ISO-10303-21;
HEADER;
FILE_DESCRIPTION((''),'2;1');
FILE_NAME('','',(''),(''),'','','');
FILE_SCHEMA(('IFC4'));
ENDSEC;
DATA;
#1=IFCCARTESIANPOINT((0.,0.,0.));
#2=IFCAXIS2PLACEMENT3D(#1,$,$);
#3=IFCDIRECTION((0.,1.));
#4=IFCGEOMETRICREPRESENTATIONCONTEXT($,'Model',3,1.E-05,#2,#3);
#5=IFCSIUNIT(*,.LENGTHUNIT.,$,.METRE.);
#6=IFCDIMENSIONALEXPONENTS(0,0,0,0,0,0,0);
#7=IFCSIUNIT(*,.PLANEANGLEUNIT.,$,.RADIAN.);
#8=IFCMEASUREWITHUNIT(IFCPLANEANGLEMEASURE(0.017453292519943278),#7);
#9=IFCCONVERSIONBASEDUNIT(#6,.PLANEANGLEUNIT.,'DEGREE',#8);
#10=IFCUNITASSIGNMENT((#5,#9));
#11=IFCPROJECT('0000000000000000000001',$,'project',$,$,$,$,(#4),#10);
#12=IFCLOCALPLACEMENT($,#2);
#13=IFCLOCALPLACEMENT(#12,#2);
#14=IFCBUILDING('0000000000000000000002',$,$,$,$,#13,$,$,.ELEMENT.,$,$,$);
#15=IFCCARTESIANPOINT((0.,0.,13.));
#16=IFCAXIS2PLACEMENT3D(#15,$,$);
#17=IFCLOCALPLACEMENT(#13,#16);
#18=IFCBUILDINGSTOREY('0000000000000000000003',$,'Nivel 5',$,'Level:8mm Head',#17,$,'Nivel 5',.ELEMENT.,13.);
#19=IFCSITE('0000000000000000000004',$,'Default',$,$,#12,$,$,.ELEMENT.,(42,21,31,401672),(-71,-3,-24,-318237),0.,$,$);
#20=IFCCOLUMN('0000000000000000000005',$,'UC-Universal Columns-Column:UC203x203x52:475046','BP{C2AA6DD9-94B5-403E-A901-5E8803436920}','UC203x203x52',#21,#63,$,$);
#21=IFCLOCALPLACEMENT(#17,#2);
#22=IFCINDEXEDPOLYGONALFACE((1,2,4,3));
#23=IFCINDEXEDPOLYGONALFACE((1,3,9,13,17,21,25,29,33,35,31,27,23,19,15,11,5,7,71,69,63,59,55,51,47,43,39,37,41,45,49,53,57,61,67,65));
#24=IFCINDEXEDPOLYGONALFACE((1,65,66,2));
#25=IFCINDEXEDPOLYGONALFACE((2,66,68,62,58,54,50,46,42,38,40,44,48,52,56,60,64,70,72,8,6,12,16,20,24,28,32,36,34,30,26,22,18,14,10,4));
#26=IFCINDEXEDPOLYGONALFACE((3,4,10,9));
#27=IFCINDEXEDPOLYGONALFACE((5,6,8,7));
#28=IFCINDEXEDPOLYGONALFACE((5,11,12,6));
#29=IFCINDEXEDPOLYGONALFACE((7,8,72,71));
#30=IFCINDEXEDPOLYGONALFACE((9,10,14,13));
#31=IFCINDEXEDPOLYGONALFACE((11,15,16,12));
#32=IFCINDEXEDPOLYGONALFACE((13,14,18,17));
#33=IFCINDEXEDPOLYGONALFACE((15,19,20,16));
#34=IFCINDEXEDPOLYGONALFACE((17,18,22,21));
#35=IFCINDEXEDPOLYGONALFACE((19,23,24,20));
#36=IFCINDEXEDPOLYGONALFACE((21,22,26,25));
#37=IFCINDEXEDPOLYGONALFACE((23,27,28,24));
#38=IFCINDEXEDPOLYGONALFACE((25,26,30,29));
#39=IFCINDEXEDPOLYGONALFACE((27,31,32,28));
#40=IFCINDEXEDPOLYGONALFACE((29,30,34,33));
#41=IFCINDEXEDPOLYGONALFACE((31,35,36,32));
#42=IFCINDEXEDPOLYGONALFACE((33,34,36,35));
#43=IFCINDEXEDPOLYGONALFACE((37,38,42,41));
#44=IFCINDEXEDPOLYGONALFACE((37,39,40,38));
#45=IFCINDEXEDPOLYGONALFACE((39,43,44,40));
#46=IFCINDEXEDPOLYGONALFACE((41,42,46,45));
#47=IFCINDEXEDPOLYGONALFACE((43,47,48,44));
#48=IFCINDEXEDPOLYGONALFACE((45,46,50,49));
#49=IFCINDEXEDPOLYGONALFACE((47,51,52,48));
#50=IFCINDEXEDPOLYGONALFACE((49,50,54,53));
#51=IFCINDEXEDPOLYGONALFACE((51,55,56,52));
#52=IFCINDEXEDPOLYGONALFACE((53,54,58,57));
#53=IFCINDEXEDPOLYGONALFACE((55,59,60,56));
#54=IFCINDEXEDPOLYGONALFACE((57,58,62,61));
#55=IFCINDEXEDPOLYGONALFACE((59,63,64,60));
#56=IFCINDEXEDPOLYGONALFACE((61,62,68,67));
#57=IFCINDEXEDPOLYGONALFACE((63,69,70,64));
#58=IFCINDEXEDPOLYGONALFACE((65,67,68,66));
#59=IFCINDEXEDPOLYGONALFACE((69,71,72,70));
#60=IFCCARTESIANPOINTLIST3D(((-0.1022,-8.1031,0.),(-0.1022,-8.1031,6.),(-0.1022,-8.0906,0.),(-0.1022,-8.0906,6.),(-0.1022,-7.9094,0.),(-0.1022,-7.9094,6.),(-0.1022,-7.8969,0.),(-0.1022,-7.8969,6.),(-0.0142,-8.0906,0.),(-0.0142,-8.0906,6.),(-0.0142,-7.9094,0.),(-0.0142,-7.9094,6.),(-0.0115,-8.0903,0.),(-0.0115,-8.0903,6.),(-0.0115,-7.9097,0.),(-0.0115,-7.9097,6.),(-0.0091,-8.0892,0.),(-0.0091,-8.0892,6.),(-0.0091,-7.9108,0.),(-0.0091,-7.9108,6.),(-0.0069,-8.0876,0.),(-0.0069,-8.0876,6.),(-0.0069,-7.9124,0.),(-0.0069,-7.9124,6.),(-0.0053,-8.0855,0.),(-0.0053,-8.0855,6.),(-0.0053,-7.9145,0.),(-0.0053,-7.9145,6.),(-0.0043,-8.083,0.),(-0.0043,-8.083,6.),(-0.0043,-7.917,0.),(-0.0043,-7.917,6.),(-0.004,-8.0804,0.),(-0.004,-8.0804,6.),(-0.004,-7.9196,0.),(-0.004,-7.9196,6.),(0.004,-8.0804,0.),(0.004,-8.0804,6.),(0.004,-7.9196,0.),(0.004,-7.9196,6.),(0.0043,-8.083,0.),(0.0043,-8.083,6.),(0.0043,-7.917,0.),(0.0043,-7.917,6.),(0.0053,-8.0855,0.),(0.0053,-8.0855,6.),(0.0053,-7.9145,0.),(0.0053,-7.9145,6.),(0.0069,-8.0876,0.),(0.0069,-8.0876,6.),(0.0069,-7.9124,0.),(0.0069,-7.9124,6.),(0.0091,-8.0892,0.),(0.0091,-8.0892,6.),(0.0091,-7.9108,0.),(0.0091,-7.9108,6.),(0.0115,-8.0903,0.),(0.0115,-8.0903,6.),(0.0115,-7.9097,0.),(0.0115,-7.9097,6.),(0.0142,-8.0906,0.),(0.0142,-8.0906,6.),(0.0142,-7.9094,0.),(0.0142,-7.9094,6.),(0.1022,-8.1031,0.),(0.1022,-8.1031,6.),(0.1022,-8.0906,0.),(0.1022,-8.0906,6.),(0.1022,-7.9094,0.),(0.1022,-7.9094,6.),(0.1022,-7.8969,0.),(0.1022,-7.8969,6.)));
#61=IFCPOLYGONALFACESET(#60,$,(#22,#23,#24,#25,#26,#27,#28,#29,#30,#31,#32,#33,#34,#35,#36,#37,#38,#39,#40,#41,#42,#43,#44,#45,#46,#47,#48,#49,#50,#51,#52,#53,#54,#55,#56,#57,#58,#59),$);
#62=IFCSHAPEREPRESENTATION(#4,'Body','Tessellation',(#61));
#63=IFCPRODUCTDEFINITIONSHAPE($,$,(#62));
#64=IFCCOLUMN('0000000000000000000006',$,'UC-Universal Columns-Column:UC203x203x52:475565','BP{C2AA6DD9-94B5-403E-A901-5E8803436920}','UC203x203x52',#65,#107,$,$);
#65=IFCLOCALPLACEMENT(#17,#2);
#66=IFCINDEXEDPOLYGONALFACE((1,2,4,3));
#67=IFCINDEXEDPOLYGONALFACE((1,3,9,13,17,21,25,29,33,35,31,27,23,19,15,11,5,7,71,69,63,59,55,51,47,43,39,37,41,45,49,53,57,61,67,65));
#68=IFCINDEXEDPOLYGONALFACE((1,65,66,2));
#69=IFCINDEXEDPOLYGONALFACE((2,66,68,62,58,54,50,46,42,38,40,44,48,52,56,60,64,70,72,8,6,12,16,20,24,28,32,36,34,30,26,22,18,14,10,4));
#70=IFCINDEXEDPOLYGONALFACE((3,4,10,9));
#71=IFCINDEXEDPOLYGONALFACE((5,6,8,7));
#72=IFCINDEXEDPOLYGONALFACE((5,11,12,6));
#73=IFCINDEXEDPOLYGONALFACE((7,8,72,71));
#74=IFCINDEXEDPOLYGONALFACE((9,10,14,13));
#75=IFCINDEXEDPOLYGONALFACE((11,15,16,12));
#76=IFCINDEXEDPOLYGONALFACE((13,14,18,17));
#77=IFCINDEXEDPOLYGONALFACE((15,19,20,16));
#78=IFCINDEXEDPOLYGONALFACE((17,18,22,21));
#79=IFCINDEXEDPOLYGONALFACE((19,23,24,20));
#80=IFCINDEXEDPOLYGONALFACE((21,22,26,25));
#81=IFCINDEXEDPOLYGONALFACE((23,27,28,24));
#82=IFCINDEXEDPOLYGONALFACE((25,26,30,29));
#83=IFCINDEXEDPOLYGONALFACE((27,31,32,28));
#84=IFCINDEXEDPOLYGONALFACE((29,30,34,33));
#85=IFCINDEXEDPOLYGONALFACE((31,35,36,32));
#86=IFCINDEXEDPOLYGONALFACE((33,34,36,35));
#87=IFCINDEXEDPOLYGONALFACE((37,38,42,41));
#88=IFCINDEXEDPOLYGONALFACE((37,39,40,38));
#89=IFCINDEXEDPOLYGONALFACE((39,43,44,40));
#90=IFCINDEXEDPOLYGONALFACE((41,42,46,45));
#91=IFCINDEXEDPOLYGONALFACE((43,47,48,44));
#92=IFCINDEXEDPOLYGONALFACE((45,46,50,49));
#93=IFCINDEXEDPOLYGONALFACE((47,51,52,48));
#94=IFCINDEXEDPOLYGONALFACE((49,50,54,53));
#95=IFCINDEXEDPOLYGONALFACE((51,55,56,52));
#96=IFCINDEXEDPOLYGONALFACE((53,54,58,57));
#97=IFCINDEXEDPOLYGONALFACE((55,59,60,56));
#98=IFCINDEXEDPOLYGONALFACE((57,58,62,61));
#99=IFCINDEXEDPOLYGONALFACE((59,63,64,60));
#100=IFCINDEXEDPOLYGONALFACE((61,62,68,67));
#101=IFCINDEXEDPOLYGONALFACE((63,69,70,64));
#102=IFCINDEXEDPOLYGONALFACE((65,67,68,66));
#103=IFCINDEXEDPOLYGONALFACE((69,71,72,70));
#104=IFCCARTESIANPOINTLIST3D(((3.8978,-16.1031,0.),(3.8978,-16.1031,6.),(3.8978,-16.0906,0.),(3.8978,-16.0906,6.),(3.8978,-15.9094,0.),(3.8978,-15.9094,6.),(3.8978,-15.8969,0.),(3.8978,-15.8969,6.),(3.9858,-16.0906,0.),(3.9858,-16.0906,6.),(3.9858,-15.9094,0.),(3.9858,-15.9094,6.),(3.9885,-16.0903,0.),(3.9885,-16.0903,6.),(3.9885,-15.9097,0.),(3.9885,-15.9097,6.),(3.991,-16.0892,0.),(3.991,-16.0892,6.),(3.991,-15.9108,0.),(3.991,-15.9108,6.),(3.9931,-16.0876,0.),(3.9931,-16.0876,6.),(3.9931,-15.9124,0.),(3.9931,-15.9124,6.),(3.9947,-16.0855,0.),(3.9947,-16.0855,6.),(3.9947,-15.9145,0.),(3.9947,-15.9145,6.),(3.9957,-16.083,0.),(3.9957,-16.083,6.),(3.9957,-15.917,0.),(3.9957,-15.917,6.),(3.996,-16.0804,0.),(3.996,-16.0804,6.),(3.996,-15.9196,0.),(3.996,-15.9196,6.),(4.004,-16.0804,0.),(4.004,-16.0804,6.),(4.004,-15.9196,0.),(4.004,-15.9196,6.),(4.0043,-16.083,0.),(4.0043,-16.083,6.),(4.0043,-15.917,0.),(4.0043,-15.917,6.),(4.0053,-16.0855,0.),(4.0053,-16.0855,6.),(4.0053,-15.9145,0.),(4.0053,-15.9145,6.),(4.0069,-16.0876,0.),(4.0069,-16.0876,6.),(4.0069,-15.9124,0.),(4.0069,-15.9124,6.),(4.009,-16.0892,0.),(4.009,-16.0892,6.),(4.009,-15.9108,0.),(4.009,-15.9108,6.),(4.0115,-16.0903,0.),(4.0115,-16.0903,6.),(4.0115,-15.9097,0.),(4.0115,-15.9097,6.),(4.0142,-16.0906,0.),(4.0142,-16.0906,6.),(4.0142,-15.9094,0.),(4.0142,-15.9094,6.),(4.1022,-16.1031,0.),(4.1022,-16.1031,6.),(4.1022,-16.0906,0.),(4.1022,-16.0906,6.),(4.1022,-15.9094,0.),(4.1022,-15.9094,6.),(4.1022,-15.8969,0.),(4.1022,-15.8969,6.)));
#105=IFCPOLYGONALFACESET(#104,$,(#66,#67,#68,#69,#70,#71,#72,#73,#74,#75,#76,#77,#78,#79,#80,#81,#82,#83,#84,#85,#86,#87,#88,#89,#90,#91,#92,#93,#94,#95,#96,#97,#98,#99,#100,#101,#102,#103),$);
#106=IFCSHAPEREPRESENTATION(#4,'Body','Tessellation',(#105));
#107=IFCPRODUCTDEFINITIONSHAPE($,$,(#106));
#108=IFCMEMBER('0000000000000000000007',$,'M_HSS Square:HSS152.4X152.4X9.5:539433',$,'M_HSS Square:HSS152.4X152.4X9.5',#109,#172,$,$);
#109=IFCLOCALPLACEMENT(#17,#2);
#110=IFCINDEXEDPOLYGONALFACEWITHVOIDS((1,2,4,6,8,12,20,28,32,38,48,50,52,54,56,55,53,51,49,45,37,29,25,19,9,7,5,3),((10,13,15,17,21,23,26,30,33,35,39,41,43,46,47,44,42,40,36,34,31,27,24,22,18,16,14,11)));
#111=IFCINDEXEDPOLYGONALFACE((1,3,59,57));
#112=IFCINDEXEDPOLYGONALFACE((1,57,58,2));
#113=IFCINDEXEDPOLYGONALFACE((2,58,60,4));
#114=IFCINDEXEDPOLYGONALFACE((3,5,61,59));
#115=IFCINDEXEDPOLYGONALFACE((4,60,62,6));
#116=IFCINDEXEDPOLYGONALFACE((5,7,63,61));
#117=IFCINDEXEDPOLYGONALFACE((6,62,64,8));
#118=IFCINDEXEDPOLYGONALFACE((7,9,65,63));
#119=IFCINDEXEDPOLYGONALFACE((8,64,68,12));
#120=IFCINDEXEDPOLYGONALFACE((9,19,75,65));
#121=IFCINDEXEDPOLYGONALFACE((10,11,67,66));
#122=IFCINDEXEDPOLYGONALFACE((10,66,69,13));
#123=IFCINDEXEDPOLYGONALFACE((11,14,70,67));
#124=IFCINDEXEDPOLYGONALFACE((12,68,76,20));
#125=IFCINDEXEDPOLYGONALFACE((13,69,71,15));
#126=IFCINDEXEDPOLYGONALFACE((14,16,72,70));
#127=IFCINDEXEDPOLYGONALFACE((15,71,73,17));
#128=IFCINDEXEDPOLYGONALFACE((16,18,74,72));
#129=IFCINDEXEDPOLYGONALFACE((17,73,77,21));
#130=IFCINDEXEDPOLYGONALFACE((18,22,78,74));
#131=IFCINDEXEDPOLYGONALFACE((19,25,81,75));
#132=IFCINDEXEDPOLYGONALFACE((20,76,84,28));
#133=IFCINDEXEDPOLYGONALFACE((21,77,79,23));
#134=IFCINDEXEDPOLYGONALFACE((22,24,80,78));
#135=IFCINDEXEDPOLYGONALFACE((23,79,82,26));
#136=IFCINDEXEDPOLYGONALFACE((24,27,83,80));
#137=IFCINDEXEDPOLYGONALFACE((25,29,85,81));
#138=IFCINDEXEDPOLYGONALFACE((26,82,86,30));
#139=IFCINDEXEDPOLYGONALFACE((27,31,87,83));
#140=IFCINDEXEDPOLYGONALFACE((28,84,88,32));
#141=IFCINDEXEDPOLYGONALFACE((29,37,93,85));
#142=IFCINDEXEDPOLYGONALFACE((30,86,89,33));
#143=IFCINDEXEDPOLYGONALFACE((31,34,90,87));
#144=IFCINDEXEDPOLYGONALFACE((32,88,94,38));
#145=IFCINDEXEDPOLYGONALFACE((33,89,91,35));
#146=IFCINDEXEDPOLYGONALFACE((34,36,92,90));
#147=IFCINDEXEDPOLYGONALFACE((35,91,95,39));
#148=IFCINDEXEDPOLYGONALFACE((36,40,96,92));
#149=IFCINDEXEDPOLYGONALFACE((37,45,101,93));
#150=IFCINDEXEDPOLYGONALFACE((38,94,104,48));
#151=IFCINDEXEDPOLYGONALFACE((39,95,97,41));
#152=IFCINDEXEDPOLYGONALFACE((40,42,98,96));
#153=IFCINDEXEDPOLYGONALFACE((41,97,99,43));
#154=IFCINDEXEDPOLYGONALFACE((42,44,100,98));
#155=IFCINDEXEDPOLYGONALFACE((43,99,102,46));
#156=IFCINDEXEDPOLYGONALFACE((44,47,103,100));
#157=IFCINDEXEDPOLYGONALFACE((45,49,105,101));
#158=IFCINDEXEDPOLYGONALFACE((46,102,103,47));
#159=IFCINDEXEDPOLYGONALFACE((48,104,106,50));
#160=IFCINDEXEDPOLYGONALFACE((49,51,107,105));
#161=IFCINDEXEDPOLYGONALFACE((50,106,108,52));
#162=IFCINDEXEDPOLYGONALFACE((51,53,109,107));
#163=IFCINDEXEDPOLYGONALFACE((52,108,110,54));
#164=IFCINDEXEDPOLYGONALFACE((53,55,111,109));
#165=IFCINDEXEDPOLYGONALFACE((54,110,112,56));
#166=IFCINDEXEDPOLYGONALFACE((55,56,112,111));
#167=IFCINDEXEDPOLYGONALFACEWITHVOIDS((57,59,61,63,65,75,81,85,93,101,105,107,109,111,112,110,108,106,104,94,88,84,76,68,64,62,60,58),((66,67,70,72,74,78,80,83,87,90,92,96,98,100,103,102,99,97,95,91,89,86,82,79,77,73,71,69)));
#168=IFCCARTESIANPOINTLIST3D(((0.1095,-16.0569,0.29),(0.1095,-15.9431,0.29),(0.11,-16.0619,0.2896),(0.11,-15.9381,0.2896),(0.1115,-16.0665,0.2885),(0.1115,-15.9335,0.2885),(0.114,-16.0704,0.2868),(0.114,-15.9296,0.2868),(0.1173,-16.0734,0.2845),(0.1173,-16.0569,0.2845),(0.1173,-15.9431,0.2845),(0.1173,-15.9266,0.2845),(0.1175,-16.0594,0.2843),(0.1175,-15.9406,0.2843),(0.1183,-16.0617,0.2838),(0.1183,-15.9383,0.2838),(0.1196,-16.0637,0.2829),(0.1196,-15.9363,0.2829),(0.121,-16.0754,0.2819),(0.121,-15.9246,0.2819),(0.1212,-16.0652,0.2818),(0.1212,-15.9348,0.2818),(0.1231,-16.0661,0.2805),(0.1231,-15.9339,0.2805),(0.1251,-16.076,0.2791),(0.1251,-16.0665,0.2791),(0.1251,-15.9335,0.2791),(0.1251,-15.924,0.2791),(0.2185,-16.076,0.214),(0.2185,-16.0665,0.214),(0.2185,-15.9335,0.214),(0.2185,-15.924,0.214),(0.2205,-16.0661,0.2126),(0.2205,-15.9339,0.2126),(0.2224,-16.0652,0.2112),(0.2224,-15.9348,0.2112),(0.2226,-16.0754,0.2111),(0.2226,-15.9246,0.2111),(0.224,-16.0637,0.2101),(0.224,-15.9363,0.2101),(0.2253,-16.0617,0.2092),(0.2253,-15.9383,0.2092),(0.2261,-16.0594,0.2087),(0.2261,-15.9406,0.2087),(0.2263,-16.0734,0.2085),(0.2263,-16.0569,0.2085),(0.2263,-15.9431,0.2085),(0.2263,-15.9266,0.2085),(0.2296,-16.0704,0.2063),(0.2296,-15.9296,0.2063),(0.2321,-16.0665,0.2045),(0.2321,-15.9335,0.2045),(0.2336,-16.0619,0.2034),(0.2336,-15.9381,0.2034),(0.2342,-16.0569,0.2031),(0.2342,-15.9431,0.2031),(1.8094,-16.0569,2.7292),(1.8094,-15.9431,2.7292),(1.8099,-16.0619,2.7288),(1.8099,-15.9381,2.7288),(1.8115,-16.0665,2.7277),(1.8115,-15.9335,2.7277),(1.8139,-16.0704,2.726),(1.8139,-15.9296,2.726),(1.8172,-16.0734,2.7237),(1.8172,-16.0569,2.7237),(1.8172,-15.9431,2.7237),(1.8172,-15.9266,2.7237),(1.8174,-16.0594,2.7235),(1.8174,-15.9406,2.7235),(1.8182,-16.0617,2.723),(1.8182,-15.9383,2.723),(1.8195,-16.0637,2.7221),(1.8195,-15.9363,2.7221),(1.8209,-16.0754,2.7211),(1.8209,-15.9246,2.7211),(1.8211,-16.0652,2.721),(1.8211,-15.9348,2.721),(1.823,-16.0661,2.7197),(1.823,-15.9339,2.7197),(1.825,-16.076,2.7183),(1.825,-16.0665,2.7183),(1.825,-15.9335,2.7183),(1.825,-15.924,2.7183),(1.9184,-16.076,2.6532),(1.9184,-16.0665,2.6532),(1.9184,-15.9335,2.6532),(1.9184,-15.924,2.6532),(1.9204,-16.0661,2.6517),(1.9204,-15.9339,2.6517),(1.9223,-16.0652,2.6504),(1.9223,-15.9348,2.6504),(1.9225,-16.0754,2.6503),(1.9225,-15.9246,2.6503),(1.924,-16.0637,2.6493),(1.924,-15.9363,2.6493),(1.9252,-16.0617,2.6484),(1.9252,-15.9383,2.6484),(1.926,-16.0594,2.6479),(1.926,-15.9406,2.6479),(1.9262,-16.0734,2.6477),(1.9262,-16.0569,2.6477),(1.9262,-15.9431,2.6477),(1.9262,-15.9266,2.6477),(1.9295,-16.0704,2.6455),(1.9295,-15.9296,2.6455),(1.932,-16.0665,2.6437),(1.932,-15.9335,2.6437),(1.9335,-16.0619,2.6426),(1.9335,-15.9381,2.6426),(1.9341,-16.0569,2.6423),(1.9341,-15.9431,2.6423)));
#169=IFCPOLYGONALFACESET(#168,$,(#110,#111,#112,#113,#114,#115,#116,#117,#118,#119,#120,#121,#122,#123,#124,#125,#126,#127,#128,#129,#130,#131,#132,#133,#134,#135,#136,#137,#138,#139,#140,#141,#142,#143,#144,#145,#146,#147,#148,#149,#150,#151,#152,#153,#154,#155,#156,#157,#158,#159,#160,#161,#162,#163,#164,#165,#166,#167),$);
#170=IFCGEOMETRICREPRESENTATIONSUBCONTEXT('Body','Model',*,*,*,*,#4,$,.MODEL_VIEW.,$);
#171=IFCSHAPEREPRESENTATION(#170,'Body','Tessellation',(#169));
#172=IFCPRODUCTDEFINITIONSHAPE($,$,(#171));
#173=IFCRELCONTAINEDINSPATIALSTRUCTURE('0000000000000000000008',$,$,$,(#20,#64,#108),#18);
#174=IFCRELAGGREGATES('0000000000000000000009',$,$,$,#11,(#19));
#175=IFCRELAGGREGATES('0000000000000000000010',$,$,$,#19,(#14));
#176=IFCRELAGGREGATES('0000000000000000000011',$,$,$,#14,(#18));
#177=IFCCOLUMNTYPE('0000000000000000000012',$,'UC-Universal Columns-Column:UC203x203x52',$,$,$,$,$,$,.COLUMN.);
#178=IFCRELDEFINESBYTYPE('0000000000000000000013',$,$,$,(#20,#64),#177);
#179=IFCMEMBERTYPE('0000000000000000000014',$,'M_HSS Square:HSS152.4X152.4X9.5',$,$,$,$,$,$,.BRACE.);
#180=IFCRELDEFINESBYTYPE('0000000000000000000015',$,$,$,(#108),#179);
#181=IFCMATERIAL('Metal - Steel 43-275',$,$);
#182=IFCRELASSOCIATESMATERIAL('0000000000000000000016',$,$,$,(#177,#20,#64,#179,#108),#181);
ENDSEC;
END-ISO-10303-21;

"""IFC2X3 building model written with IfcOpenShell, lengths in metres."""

from ifc_helpers import new_model, entity, si_unit, converted_unit, direction, frame, frame_2d, origin, origin_2d, place, context, subcontext, project, spatial, polyline, circle_curve, parameter, trimmed, segment, composite_curve, i_section, outline, extrude, source, transform, mapped, material, type_object, type_shapes, element, save


model = new_model("IFC2X3")

# Units and contexts
model_context = context("Model", 3, precision=1e-05, world=origin(), true_north=direction((0.0, 1.0)))
body_context = subcontext(model_context, "Body", "Model", "MODEL_VIEW")
ifc_project = project(units=[si_unit("LENGTHUNIT", "METRE"), converted_unit("PLANEANGLEUNIT", "DEGREE", entity("IfcPlaneAngleMeasure", 0.017453292519943278), si_unit("PLANEANGLEUNIT", "RADIAN"), dimensions=[0, 0, 0, 0, 0, 0, 0])], contexts=[model_context])

# Site, building, storey
site_placement = place(None, origin())
site = spatial("IfcSite", under=ifc_project, at=site_placement, Name="Default", CompositionType="ELEMENT", RefLatitude=(42, 21, 31, 401672), RefLongitude=(-71, -3, -24, -318237), RefElevation=0.0)
building_placement = place(site_placement, origin())
building = spatial("IfcBuilding", under=site, at=building_placement, CompositionType="ELEMENT")
storey_placement = place(building_placement, frame((0.0, 0.0, 13.0)))
storey = spatial("IfcBuildingStorey", under=building, at=storey_placement, Name="Nivel 5", ObjectType="Level:8mm Head", LongName="Nivel 5", CompositionType="ELEMENT", Elevation=13.0)

# Columns
ifc_material_1 = material(Name="Metal - Steel 43-275")
column_type_1 = type_object("IfcColumnType", Name="UC-Universal Columns-Column:UC203x203x52", PredefinedType="COLUMN", material=ifc_material_1)
for number, where, name in (
    (1, (0.0, -8.0, 6.0), "UC-Universal Columns-Column:UC203x203x52:475046"),
    (2, (4.0, -16.0, 6.0), "UC-Universal Columns-Column:UC203x203x52:475565"),
):
    element("IfcColumn", number, at=place(storey_placement, frame(where)), inside=storey, type_object=column_type_1, material=ifc_material_1, Name=name, Description="BP{C2AA6DD9-94B5-403E-A901-5E8803436920}", ObjectType="UC203x203x52", context=model_context, shape_type="SweptSolid", body=[
        extrude(i_section(OverallWidth=0.2043, OverallDepth=0.2062, WebThickness=0.0079, FlangeThickness=0.0125, FilletRadius=0.0102, at=origin_2d()), origin(), (0.0, 0.0, -1.0), 6.0),
    ])

# Member
member_type_1 = type_object("IfcMemberType", Name="M_HSS Square:HSS152.4X152.4X9.5", PredefinedType="BRACE", material=ifc_material_1)
shared_shape_1 = source(origin(), body_context, "Body", "SweptSolid", [
    extrude(outline(composite_curve([segment(polyline([(-0.0569, -0.076), (0.0569, -0.076)]), True, "CONTINUOUS"), segment(trimmed(circle_curve(frame_2d((0.0569, -0.0569), x_axis=(0.0, 1.0)), 0.0191), [parameter(180.0)], [parameter(270.0)], True, "PARAMETER"), True, "CONTINUOUS"), segment(polyline([(0.076, -0.0569), (0.076, 0.0569)]), True, "CONTINUOUS"), segment(trimmed(circle_curve(frame_2d((0.0569, 0.0569), x_axis=(0.0, 1.0)), 0.0191), [parameter(270.0)], [parameter(0.0)], True, "PARAMETER"), True, "CONTINUOUS"), segment(polyline([(0.0569, 0.076), (-0.0569, 0.076)]), True, "CONTINUOUS"), segment(trimmed(circle_curve(frame_2d((-0.0569, 0.0569), x_axis=(0.0, 1.0)), 0.0191), [parameter(0.0)], [parameter(90.0)], True, "PARAMETER"), True, "CONTINUOUS"), segment(polyline([(-0.076, 0.0569), (-0.076, -0.0569)]), True, "CONTINUOUS"), segment(trimmed(circle_curve(frame_2d((-0.0569, -0.0569), x_axis=(0.0, 1.0)), 0.0191), [parameter(90.0)], [parameter(180.0)], True, "PARAMETER"), True, "CONTINUOUS")], self_intersect=False), holes=[composite_curve([segment(trimmed(circle_curve(frame_2d((-0.0569, 0.0569), x_axis=(0.0, 1.0)), 0.0095), [parameter(360.0)], [parameter(90.0)], True, "PARAMETER"), False, "CONTINUOUS"), segment(polyline([(-0.0569, 0.0665), (0.0569, 0.0665)]), True, "CONTINUOUS"), segment(trimmed(circle_curve(frame_2d((0.0569, 0.0569), x_axis=(0.0, 1.0)), 0.0095), [parameter(270.0)], [parameter(360.0)], True, "PARAMETER"), False, "CONTINUOUS"), segment(polyline([(0.0665, 0.0569), (0.0665, -0.0569)]), True, "CONTINUOUS"), segment(trimmed(circle_curve(frame_2d((0.0569, -0.0569), x_axis=(0.0, 1.0)), 0.0095), [parameter(180.0)], [parameter(270.0)], True, "PARAMETER"), False, "CONTINUOUS"), segment(polyline([(0.0569, -0.0665), (-0.0569, -0.0665)]), True, "CONTINUOUS"), segment(trimmed(circle_curve(frame_2d((-0.0569, -0.0569), x_axis=(0.0, 1.0)), 0.0095), [parameter(90.0)], [parameter(180.0)], True, "PARAMETER"), False, "CONTINUOUS"), segment(polyline([(-0.0665, -0.0569), (-0.0665, 0.0569)]), True, "CONTINUOUS")], self_intersect=False)]), frame((-1.4485, 0.0, 0.0), z_axis=(1.0, 0.0, 0.0), x_axis=(0.0, 0.0, -1.0)), (0.0, 0.0, 1.0), 2.9731),
])
type_shapes(member_type_1, [shared_shape_1])
member_1_placement = place(storey_placement, frame((1.0, -16.0, 1.4349), z_axis=(-0.82042, 0.0, 0.571761), x_axis=(0.571761, 0.0, 0.82042)))
element("IfcMember", 3, at=member_1_placement, inside=storey, type_object=member_type_1, material=ifc_material_1, Name="M_HSS Square:HSS152.4X152.4X9.5:539433", ObjectType="M_HSS Square:HSS152.4X152.4X9.5", context=body_context, shape_type="MappedRepresentation", body=[
    mapped(shared_shape_1, transform((0.0, 0.0, 0.0), scale=1.0)),
])

save(model, "model.ifc")
